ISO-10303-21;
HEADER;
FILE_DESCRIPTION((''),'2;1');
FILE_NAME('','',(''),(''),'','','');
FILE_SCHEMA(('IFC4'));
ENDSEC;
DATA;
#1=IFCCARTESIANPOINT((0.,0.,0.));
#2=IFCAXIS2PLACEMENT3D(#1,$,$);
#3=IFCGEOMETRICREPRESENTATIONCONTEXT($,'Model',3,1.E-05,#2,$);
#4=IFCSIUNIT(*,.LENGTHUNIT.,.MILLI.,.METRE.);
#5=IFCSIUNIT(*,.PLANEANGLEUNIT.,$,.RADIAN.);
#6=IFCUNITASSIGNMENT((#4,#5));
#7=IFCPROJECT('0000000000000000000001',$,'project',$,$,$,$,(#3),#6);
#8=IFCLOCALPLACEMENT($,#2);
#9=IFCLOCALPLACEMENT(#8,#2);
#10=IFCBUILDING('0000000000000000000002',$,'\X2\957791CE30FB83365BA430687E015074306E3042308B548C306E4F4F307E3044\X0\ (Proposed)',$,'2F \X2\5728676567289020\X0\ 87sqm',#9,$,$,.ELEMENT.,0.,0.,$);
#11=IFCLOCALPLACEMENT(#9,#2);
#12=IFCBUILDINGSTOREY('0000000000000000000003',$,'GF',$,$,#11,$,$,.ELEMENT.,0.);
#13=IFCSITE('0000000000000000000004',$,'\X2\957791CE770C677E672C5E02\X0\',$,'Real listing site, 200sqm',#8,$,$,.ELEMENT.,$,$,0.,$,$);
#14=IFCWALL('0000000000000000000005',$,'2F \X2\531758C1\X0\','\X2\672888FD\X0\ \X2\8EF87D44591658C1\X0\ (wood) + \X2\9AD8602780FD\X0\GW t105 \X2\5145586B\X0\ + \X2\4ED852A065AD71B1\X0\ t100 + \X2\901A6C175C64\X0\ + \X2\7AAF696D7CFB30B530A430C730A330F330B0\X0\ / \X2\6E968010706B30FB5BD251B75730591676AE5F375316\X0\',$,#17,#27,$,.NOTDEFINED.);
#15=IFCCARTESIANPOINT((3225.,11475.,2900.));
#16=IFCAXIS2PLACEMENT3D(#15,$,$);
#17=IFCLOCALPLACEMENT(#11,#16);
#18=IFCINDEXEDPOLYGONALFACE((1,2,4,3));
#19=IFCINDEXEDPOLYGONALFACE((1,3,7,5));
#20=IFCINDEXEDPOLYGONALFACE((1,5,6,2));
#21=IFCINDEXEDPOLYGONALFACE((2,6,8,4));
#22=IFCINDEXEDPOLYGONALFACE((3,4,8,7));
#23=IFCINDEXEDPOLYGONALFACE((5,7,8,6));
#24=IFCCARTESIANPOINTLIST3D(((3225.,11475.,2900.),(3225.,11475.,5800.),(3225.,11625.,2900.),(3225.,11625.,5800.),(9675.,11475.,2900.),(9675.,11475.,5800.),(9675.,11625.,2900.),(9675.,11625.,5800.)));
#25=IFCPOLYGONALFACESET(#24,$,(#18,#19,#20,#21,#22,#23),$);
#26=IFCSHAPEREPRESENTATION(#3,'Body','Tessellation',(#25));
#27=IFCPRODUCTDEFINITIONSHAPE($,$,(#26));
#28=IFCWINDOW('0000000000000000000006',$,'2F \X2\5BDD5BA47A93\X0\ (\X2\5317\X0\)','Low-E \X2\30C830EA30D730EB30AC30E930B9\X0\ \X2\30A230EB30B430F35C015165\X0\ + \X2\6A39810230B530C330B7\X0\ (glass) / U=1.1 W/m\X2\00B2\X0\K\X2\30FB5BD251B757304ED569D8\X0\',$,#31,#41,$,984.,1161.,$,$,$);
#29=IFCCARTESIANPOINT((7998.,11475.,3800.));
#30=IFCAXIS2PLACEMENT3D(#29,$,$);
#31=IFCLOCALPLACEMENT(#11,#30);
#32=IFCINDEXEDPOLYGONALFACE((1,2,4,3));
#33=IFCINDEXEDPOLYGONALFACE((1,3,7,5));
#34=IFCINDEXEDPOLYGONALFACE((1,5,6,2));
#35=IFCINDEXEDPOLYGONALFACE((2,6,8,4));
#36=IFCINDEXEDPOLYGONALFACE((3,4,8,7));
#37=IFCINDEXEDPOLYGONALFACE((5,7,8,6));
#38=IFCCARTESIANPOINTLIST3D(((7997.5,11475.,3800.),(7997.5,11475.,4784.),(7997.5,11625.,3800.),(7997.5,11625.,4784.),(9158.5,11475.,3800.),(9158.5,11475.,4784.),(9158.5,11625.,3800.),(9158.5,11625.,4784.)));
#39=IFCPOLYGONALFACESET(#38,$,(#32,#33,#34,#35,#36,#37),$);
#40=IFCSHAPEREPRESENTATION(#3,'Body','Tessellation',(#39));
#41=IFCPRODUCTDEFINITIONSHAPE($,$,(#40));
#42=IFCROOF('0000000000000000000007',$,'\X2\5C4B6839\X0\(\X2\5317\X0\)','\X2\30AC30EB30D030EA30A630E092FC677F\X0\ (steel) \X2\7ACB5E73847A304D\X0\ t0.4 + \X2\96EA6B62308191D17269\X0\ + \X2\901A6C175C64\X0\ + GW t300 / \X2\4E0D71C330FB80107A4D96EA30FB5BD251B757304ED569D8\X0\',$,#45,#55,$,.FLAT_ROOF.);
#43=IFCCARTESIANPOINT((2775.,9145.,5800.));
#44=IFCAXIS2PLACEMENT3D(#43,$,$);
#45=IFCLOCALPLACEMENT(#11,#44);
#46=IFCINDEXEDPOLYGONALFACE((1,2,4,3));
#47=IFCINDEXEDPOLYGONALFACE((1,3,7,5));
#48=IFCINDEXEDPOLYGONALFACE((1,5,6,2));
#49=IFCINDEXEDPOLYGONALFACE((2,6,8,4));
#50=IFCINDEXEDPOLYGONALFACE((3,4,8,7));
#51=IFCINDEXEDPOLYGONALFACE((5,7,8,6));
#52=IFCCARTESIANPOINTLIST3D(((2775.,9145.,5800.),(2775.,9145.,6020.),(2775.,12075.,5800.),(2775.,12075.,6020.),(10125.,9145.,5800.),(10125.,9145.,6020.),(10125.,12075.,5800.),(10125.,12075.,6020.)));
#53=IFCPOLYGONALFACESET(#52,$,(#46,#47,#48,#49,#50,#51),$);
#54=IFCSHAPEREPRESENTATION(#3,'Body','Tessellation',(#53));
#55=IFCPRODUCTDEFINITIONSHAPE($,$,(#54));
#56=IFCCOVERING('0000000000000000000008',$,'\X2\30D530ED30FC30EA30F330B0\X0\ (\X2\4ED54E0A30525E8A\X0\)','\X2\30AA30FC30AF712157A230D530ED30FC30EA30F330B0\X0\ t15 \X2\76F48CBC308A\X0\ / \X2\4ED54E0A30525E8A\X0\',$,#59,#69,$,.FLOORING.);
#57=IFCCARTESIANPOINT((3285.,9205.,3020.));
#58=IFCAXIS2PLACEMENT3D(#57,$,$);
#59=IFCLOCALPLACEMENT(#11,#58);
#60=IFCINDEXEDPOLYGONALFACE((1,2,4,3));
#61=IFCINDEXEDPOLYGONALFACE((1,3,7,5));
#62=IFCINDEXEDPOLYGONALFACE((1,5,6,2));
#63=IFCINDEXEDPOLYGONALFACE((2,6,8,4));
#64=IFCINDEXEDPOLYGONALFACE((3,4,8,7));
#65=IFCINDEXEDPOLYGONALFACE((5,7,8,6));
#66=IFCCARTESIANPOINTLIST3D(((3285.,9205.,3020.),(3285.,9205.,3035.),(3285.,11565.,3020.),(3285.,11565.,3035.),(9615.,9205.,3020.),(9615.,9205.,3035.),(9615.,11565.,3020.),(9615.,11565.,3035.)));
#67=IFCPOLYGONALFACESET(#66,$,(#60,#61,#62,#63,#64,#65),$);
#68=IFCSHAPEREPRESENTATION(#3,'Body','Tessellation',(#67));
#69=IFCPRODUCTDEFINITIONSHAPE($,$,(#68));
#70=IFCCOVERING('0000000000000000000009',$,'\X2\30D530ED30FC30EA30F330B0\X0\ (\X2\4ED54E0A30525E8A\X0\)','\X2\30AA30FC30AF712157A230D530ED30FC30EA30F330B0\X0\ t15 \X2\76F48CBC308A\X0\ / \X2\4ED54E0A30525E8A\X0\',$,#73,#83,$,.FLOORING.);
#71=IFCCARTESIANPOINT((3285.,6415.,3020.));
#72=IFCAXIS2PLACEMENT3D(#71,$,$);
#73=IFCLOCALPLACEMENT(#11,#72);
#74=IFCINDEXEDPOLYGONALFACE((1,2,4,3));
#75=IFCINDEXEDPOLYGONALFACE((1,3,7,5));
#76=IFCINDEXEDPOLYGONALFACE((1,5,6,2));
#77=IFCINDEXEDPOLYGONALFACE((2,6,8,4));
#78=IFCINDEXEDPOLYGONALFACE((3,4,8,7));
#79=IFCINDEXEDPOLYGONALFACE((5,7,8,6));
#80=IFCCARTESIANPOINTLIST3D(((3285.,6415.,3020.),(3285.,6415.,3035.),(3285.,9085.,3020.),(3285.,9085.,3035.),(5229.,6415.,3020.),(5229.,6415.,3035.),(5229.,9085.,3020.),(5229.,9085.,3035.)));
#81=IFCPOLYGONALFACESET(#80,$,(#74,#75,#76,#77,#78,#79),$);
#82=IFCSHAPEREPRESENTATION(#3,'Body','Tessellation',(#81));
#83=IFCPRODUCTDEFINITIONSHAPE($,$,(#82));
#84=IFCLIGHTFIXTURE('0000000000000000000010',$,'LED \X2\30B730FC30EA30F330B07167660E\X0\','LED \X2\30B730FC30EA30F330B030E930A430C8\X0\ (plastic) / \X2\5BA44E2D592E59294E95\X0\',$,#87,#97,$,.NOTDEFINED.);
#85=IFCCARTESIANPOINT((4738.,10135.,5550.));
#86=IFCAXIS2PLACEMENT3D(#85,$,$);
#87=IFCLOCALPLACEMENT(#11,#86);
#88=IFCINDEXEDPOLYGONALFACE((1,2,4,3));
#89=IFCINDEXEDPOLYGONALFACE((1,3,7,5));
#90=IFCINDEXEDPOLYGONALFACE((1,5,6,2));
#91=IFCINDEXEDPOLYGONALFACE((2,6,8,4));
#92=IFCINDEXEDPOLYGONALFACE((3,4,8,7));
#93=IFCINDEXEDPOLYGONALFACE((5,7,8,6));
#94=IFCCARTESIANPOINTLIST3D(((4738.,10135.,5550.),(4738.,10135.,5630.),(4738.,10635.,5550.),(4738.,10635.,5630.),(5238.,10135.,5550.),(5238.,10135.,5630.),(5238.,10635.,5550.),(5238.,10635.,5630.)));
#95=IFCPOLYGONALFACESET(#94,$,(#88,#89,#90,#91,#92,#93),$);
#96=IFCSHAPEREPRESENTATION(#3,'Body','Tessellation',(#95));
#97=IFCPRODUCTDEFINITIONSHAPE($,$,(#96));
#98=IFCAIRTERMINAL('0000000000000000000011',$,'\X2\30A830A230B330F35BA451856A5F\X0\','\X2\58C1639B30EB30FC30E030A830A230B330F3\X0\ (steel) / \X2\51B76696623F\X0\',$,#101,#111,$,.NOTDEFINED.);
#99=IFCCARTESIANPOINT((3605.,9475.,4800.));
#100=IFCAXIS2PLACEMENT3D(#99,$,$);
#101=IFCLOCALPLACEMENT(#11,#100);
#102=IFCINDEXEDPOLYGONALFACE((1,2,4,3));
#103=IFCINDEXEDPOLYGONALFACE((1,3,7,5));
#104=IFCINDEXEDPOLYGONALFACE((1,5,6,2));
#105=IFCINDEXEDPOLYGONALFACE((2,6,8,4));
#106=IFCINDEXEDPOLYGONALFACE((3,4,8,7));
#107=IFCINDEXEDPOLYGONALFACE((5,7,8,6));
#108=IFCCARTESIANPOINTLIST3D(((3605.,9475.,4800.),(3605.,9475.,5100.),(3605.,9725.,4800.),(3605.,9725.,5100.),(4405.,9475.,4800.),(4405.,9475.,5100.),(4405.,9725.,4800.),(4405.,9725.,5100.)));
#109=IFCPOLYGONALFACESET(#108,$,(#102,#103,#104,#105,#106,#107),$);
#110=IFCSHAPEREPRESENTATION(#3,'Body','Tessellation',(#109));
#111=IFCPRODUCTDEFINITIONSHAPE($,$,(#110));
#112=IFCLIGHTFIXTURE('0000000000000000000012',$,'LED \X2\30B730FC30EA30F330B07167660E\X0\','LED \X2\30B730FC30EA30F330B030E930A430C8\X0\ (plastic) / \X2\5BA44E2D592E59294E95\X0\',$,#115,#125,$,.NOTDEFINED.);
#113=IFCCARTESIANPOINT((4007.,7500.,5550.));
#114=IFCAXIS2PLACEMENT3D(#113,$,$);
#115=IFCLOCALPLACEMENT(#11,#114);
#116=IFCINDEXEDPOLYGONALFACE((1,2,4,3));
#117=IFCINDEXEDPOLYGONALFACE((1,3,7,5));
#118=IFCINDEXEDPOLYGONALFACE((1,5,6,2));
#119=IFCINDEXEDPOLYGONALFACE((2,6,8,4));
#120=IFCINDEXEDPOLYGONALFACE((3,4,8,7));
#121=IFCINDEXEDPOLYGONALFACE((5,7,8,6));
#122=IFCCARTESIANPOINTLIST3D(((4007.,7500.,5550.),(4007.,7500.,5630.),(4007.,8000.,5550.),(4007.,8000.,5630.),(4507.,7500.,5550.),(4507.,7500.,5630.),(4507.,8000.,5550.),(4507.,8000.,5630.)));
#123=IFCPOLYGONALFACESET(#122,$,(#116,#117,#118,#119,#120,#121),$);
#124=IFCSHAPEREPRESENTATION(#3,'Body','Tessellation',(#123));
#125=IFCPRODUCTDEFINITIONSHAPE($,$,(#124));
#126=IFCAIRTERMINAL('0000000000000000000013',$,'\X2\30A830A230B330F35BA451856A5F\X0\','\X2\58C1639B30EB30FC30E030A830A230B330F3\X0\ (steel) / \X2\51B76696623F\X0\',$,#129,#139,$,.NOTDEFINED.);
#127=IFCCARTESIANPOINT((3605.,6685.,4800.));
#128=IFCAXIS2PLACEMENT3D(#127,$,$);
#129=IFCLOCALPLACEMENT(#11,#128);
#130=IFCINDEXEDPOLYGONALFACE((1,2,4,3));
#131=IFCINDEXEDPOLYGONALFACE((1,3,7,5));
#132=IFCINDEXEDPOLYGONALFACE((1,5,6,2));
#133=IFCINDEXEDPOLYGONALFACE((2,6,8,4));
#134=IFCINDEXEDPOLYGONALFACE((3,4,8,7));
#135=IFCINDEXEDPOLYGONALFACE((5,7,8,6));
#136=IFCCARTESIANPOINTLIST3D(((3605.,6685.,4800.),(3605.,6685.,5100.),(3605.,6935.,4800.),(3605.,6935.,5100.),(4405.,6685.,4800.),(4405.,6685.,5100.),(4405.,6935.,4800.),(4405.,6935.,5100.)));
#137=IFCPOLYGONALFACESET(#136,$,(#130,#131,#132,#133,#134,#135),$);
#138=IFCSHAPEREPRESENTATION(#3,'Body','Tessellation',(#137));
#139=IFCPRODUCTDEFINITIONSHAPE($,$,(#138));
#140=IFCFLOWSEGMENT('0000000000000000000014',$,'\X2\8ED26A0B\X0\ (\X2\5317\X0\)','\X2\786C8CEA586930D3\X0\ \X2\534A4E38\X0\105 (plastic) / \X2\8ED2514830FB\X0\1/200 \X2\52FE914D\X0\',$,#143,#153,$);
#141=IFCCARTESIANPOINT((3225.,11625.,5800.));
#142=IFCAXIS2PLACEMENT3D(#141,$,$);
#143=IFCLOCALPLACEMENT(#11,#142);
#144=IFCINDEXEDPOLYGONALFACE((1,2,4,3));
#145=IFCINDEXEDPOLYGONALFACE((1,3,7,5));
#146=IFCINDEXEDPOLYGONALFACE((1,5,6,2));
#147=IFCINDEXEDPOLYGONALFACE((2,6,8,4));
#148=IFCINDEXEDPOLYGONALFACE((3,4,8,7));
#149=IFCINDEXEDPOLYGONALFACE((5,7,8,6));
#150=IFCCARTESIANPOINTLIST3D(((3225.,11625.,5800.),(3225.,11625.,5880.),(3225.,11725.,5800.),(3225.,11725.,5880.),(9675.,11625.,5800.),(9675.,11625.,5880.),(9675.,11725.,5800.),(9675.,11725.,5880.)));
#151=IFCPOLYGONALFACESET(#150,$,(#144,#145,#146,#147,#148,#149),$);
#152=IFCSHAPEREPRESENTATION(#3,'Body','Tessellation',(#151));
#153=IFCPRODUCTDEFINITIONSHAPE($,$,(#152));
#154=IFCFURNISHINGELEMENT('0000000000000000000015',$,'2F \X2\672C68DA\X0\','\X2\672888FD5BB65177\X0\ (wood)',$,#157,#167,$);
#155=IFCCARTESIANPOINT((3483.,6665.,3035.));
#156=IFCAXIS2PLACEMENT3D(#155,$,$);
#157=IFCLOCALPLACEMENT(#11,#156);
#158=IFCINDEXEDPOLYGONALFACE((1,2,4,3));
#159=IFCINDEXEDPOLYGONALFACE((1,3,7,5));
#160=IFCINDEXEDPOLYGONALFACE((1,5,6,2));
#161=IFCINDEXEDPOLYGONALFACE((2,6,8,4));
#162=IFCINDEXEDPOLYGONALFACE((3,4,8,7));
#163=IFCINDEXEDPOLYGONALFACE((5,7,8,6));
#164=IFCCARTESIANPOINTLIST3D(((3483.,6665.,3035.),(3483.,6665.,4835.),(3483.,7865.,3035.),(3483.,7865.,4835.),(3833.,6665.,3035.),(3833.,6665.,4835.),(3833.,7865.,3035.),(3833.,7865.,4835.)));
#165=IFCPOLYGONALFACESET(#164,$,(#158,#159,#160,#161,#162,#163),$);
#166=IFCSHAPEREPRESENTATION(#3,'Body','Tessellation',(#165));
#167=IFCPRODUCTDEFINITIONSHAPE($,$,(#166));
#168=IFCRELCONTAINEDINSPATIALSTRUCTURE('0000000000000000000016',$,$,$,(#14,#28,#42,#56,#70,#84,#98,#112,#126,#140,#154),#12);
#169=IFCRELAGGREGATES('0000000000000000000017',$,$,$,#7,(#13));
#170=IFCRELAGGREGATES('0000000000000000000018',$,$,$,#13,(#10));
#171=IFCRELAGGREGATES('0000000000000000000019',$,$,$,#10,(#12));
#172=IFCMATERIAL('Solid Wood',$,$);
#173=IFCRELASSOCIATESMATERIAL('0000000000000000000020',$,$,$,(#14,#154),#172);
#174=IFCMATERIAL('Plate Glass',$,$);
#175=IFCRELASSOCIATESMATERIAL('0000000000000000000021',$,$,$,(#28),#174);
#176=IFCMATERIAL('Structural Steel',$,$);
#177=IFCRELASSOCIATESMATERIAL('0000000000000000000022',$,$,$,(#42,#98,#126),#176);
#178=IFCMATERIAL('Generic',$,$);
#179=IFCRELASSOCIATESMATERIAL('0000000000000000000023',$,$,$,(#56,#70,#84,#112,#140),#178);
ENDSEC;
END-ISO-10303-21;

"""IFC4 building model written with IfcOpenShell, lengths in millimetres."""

from ifc_helpers import new_model, si_unit, frame, frame_2d, origin, place, context, project, spatial, rectangle, extrude, material, element, fill, save


model = new_model("IFC4")

# Units and contexts
model_context = context("Model", 3, precision=1e-05, world=origin())
ifc_project = project(units=[si_unit("LENGTHUNIT", "METRE", prefix="MILLI"), si_unit("PLANEANGLEUNIT", "RADIAN")], contexts=[model_context])

# Site, building, storey
site_placement = place(None, origin())
site = spatial("IfcSite", under=ifc_project, at=site_placement, Name="長野県松本市", ObjectType="Real listing site, 200sqm", CompositionType="ELEMENT", RefElevation=0.0)
building_placement = place(site_placement, origin())
building = spatial("IfcBuilding", under=site, at=building_placement, Name="長野・茶室と縁側のある和の住まい (Proposed)", ObjectType="2F 在来木造 87sqm", CompositionType="ELEMENT", ElevationOfRefHeight=0.0, ElevationOfTerrain=0.0)
storey_placement = place(building_placement, origin())
storey = spatial("IfcBuildingStorey", under=building, at=storey_placement, Name="GF", CompositionType="ELEMENT", Elevation=0.0)

# Shared definitions
ifc_material_1 = material(Name="Solid Wood")

# Wall, opening, window
wall_placement = place(storey_placement, frame((3225.0, 11475.0, 2900.0)))
wall = element("IfcWall", 1, at=wall_placement, inside=storey, material=ifc_material_1, Name="2F 北壁", Description="木製 軸組外壁 (wood) + 高性能GW t105 充填 + 付加断熱 t100 + 通気層 + 窯業系サイディング / 準耐火・寒冷地外皮強化", PredefinedType="NOTDEFINED", context=model_context, shape_type="SweptSolid", body=[
    extrude(rectangle(XDim=6450.0, YDim=150.0, at=frame_2d((3225.0, 75.0))), frame((3225.0, 11475.0, 2900.0)), (0.0, 0.0, 1.0), 2900.0),
])
opening_placement = place(storey_placement, frame((7998.0, 11475.0, 3800.0)))
opening = element("IfcOpeningElement", 2, at=opening_placement, cuts=wall, PredefinedType="NOTDEFINED", context=model_context, shape_type="SweptSolid", body=[
    extrude(rectangle(XDim=1161.0, YDim=150.0, at=frame_2d((580.0, 75.0))), frame((7998.0, 11475.0, 3800.0)), (0.0, 0.0, 1.0), 984.0),
])
ifc_material_2 = material(Name="Plate Glass")
window_placement = place(storey_placement, frame((7998.0, 11475.0, 3800.0)))
window = element("IfcWindow", 3, at=window_placement, inside=storey, material=ifc_material_2, Name="2F 寝室窓 (北)", Description="Low-E トリプルガラス アルゴン封入 + 樹脂サッシ (glass) / U=1.1 W/m²K・寒冷地仕様", OverallHeight=984.0, OverallWidth=1161.0, context=model_context, shape_type="SweptSolid", body=[
    extrude(rectangle(XDim=1161.0, YDim=150.0, at=frame_2d((580.0, 75.0))), frame((7998.0, 11475.0, 3800.0)), (0.0, 0.0, 1.0), 984.0),
])
fill(opening, window)

# Roof
ifc_material_3 = material(Name="Structural Steel")
for number, where, name in (
    (4, (2775.0, 9145.0, 5800.0), "屋根(北)"),
):
    element("IfcRoof", number, at=place(storey_placement, frame(where)), inside=storey, material=ifc_material_3, Name=name, Description="ガルバリウム鋼板 (steel) 立平葺き t0.4 + 雪止め金物 + 通気層 + GW t300 / 不燃・耐積雪・寒冷地仕様", PredefinedType="FLAT_ROOF", context=model_context, shape_type="SweptSolid", body=[
        extrude(rectangle(XDim=7350.0, YDim=2930.0, at=frame_2d((3675.0, 1465.0))), frame((2775.0, 9145.0, 5800.0)), (0.0, 0.0, 1.0), 220.0),
    ])

# Coverings
ifc_material_4 = material(Name="Generic")
covering_1_placement = place(storey_placement, frame((3285.0, 9205.0, 3020.0)))
element("IfcCovering", 5, at=covering_1_placement, inside=storey, material=ifc_material_4, Name="フローリング (仕上げ床)", Description="オーク無垢フローリング t15 直貼り / 仕上げ床", PredefinedType="FLOORING", context=model_context, shape_type="SweptSolid", body=[
    extrude(rectangle(XDim=6330.0, YDim=2360.0, at=frame_2d((3165.0, 1180.0))), frame((3285.0, 9205.0, 3020.0)), (0.0, 0.0, 1.0), 15.0),
])
covering_2_placement = place(storey_placement, frame((3285.0, 6415.0, 3020.0)))
element("IfcCovering", 6, at=covering_2_placement, inside=storey, material=ifc_material_4, Name="フローリング (仕上げ床)", Description="オーク無垢フローリング t15 直貼り / 仕上げ床", PredefinedType="FLOORING", context=model_context, shape_type="SweptSolid", body=[
    extrude(rectangle(XDim=1944.0, YDim=2670.0, at=frame_2d((972.0, 1335.0))), frame((3285.0, 6415.0, 3020.0)), (0.0, 0.0, 1.0), 15.0),
])

# Light fixture
light_fixture_1_placement = place(storey_placement, frame((4738.0, 10135.0, 5550.0)))
element("IfcLightFixture", 7, at=light_fixture_1_placement, inside=storey, material=ifc_material_4, Name="LED シーリング照明", Description="LED シーリングライト (plastic) / 室中央天井", PredefinedType="NOTDEFINED", context=model_context, shape_type="SweptSolid", body=[
    extrude(rectangle(XDim=500.0, YDim=500.0, at=frame_2d((250.0, 250.0))), frame((4738.0, 10135.0, 5550.0)), (0.0, 0.0, 1.0), 80.0),
])

# Air terminal
air_terminal_1_placement = place(storey_placement, frame((3605.0, 9475.0, 4800.0)))
element("IfcAirTerminal", 8, at=air_terminal_1_placement, inside=storey, material=ifc_material_3, Name="エアコン室内機", Description="壁掛ルームエアコン (steel) / 冷暖房", PredefinedType="NOTDEFINED", context=model_context, shape_type="SweptSolid", body=[
    extrude(rectangle(XDim=800.0, YDim=250.0, at=frame_2d((400.0, 125.0))), frame((3605.0, 9475.0, 4800.0)), (0.0, 0.0, 1.0), 300.0),
])

# Light fixture
light_fixture_2_placement = place(storey_placement, frame((4007.0, 7500.0, 5550.0)))
element("IfcLightFixture", 9, at=light_fixture_2_placement, inside=storey, material=ifc_material_4, Name="LED シーリング照明", Description="LED シーリングライト (plastic) / 室中央天井", PredefinedType="NOTDEFINED", context=model_context, shape_type="SweptSolid", body=[
    extrude(rectangle(XDim=500.0, YDim=500.0, at=frame_2d((250.0, 250.0))), frame((4007.0, 7500.0, 5550.0)), (0.0, 0.0, 1.0), 80.0),
])

# Air terminal
air_terminal_2_placement = place(storey_placement, frame((3605.0, 6685.0, 4800.0)))
element("IfcAirTerminal", 10, at=air_terminal_2_placement, inside=storey, material=ifc_material_3, Name="エアコン室内機", Description="壁掛ルームエアコン (steel) / 冷暖房", PredefinedType="NOTDEFINED", context=model_context, shape_type="SweptSolid", body=[
    extrude(rectangle(XDim=800.0, YDim=250.0, at=frame_2d((400.0, 125.0))), frame((3605.0, 6685.0, 4800.0)), (0.0, 0.0, 1.0), 300.0),
])

# Flow segment
flow_segment_placement = place(storey_placement, frame((3225.0, 11625.0, 5800.0)))
element("IfcFlowSegment", 11, at=flow_segment_placement, inside=storey, material=ifc_material_4, Name="軒樋 (北)", Description="硬質塩ビ 半丸105 (plastic) / 軒先・1/200 勾配", context=model_context, shape_type="SweptSolid", body=[
    extrude(rectangle(XDim=6450.0, YDim=100.0, at=frame_2d((3225.0, 50.0))), frame((3225.0, 11625.0, 5800.0)), (0.0, 0.0, 1.0), 80.0),
])

# Furnishing element
furnishing_placement = place(storey_placement, frame((3483.0, 6665.0, 3035.0)))
element("IfcFurnishingElement", 12, at=furnishing_placement, inside=storey, material=ifc_material_1, Name="2F 本棚", Description="木製家具 (wood)", context=model_context, shape_type="SweptSolid", body=[
    extrude(rectangle(XDim=350.0, YDim=1200.0, at=frame_2d((175.0, 600.0))), frame((3483.0, 6665.0, 3035.0)), (0.0, 0.0, 1.0), 1800.0),
])

save(model, "model.ifc")
